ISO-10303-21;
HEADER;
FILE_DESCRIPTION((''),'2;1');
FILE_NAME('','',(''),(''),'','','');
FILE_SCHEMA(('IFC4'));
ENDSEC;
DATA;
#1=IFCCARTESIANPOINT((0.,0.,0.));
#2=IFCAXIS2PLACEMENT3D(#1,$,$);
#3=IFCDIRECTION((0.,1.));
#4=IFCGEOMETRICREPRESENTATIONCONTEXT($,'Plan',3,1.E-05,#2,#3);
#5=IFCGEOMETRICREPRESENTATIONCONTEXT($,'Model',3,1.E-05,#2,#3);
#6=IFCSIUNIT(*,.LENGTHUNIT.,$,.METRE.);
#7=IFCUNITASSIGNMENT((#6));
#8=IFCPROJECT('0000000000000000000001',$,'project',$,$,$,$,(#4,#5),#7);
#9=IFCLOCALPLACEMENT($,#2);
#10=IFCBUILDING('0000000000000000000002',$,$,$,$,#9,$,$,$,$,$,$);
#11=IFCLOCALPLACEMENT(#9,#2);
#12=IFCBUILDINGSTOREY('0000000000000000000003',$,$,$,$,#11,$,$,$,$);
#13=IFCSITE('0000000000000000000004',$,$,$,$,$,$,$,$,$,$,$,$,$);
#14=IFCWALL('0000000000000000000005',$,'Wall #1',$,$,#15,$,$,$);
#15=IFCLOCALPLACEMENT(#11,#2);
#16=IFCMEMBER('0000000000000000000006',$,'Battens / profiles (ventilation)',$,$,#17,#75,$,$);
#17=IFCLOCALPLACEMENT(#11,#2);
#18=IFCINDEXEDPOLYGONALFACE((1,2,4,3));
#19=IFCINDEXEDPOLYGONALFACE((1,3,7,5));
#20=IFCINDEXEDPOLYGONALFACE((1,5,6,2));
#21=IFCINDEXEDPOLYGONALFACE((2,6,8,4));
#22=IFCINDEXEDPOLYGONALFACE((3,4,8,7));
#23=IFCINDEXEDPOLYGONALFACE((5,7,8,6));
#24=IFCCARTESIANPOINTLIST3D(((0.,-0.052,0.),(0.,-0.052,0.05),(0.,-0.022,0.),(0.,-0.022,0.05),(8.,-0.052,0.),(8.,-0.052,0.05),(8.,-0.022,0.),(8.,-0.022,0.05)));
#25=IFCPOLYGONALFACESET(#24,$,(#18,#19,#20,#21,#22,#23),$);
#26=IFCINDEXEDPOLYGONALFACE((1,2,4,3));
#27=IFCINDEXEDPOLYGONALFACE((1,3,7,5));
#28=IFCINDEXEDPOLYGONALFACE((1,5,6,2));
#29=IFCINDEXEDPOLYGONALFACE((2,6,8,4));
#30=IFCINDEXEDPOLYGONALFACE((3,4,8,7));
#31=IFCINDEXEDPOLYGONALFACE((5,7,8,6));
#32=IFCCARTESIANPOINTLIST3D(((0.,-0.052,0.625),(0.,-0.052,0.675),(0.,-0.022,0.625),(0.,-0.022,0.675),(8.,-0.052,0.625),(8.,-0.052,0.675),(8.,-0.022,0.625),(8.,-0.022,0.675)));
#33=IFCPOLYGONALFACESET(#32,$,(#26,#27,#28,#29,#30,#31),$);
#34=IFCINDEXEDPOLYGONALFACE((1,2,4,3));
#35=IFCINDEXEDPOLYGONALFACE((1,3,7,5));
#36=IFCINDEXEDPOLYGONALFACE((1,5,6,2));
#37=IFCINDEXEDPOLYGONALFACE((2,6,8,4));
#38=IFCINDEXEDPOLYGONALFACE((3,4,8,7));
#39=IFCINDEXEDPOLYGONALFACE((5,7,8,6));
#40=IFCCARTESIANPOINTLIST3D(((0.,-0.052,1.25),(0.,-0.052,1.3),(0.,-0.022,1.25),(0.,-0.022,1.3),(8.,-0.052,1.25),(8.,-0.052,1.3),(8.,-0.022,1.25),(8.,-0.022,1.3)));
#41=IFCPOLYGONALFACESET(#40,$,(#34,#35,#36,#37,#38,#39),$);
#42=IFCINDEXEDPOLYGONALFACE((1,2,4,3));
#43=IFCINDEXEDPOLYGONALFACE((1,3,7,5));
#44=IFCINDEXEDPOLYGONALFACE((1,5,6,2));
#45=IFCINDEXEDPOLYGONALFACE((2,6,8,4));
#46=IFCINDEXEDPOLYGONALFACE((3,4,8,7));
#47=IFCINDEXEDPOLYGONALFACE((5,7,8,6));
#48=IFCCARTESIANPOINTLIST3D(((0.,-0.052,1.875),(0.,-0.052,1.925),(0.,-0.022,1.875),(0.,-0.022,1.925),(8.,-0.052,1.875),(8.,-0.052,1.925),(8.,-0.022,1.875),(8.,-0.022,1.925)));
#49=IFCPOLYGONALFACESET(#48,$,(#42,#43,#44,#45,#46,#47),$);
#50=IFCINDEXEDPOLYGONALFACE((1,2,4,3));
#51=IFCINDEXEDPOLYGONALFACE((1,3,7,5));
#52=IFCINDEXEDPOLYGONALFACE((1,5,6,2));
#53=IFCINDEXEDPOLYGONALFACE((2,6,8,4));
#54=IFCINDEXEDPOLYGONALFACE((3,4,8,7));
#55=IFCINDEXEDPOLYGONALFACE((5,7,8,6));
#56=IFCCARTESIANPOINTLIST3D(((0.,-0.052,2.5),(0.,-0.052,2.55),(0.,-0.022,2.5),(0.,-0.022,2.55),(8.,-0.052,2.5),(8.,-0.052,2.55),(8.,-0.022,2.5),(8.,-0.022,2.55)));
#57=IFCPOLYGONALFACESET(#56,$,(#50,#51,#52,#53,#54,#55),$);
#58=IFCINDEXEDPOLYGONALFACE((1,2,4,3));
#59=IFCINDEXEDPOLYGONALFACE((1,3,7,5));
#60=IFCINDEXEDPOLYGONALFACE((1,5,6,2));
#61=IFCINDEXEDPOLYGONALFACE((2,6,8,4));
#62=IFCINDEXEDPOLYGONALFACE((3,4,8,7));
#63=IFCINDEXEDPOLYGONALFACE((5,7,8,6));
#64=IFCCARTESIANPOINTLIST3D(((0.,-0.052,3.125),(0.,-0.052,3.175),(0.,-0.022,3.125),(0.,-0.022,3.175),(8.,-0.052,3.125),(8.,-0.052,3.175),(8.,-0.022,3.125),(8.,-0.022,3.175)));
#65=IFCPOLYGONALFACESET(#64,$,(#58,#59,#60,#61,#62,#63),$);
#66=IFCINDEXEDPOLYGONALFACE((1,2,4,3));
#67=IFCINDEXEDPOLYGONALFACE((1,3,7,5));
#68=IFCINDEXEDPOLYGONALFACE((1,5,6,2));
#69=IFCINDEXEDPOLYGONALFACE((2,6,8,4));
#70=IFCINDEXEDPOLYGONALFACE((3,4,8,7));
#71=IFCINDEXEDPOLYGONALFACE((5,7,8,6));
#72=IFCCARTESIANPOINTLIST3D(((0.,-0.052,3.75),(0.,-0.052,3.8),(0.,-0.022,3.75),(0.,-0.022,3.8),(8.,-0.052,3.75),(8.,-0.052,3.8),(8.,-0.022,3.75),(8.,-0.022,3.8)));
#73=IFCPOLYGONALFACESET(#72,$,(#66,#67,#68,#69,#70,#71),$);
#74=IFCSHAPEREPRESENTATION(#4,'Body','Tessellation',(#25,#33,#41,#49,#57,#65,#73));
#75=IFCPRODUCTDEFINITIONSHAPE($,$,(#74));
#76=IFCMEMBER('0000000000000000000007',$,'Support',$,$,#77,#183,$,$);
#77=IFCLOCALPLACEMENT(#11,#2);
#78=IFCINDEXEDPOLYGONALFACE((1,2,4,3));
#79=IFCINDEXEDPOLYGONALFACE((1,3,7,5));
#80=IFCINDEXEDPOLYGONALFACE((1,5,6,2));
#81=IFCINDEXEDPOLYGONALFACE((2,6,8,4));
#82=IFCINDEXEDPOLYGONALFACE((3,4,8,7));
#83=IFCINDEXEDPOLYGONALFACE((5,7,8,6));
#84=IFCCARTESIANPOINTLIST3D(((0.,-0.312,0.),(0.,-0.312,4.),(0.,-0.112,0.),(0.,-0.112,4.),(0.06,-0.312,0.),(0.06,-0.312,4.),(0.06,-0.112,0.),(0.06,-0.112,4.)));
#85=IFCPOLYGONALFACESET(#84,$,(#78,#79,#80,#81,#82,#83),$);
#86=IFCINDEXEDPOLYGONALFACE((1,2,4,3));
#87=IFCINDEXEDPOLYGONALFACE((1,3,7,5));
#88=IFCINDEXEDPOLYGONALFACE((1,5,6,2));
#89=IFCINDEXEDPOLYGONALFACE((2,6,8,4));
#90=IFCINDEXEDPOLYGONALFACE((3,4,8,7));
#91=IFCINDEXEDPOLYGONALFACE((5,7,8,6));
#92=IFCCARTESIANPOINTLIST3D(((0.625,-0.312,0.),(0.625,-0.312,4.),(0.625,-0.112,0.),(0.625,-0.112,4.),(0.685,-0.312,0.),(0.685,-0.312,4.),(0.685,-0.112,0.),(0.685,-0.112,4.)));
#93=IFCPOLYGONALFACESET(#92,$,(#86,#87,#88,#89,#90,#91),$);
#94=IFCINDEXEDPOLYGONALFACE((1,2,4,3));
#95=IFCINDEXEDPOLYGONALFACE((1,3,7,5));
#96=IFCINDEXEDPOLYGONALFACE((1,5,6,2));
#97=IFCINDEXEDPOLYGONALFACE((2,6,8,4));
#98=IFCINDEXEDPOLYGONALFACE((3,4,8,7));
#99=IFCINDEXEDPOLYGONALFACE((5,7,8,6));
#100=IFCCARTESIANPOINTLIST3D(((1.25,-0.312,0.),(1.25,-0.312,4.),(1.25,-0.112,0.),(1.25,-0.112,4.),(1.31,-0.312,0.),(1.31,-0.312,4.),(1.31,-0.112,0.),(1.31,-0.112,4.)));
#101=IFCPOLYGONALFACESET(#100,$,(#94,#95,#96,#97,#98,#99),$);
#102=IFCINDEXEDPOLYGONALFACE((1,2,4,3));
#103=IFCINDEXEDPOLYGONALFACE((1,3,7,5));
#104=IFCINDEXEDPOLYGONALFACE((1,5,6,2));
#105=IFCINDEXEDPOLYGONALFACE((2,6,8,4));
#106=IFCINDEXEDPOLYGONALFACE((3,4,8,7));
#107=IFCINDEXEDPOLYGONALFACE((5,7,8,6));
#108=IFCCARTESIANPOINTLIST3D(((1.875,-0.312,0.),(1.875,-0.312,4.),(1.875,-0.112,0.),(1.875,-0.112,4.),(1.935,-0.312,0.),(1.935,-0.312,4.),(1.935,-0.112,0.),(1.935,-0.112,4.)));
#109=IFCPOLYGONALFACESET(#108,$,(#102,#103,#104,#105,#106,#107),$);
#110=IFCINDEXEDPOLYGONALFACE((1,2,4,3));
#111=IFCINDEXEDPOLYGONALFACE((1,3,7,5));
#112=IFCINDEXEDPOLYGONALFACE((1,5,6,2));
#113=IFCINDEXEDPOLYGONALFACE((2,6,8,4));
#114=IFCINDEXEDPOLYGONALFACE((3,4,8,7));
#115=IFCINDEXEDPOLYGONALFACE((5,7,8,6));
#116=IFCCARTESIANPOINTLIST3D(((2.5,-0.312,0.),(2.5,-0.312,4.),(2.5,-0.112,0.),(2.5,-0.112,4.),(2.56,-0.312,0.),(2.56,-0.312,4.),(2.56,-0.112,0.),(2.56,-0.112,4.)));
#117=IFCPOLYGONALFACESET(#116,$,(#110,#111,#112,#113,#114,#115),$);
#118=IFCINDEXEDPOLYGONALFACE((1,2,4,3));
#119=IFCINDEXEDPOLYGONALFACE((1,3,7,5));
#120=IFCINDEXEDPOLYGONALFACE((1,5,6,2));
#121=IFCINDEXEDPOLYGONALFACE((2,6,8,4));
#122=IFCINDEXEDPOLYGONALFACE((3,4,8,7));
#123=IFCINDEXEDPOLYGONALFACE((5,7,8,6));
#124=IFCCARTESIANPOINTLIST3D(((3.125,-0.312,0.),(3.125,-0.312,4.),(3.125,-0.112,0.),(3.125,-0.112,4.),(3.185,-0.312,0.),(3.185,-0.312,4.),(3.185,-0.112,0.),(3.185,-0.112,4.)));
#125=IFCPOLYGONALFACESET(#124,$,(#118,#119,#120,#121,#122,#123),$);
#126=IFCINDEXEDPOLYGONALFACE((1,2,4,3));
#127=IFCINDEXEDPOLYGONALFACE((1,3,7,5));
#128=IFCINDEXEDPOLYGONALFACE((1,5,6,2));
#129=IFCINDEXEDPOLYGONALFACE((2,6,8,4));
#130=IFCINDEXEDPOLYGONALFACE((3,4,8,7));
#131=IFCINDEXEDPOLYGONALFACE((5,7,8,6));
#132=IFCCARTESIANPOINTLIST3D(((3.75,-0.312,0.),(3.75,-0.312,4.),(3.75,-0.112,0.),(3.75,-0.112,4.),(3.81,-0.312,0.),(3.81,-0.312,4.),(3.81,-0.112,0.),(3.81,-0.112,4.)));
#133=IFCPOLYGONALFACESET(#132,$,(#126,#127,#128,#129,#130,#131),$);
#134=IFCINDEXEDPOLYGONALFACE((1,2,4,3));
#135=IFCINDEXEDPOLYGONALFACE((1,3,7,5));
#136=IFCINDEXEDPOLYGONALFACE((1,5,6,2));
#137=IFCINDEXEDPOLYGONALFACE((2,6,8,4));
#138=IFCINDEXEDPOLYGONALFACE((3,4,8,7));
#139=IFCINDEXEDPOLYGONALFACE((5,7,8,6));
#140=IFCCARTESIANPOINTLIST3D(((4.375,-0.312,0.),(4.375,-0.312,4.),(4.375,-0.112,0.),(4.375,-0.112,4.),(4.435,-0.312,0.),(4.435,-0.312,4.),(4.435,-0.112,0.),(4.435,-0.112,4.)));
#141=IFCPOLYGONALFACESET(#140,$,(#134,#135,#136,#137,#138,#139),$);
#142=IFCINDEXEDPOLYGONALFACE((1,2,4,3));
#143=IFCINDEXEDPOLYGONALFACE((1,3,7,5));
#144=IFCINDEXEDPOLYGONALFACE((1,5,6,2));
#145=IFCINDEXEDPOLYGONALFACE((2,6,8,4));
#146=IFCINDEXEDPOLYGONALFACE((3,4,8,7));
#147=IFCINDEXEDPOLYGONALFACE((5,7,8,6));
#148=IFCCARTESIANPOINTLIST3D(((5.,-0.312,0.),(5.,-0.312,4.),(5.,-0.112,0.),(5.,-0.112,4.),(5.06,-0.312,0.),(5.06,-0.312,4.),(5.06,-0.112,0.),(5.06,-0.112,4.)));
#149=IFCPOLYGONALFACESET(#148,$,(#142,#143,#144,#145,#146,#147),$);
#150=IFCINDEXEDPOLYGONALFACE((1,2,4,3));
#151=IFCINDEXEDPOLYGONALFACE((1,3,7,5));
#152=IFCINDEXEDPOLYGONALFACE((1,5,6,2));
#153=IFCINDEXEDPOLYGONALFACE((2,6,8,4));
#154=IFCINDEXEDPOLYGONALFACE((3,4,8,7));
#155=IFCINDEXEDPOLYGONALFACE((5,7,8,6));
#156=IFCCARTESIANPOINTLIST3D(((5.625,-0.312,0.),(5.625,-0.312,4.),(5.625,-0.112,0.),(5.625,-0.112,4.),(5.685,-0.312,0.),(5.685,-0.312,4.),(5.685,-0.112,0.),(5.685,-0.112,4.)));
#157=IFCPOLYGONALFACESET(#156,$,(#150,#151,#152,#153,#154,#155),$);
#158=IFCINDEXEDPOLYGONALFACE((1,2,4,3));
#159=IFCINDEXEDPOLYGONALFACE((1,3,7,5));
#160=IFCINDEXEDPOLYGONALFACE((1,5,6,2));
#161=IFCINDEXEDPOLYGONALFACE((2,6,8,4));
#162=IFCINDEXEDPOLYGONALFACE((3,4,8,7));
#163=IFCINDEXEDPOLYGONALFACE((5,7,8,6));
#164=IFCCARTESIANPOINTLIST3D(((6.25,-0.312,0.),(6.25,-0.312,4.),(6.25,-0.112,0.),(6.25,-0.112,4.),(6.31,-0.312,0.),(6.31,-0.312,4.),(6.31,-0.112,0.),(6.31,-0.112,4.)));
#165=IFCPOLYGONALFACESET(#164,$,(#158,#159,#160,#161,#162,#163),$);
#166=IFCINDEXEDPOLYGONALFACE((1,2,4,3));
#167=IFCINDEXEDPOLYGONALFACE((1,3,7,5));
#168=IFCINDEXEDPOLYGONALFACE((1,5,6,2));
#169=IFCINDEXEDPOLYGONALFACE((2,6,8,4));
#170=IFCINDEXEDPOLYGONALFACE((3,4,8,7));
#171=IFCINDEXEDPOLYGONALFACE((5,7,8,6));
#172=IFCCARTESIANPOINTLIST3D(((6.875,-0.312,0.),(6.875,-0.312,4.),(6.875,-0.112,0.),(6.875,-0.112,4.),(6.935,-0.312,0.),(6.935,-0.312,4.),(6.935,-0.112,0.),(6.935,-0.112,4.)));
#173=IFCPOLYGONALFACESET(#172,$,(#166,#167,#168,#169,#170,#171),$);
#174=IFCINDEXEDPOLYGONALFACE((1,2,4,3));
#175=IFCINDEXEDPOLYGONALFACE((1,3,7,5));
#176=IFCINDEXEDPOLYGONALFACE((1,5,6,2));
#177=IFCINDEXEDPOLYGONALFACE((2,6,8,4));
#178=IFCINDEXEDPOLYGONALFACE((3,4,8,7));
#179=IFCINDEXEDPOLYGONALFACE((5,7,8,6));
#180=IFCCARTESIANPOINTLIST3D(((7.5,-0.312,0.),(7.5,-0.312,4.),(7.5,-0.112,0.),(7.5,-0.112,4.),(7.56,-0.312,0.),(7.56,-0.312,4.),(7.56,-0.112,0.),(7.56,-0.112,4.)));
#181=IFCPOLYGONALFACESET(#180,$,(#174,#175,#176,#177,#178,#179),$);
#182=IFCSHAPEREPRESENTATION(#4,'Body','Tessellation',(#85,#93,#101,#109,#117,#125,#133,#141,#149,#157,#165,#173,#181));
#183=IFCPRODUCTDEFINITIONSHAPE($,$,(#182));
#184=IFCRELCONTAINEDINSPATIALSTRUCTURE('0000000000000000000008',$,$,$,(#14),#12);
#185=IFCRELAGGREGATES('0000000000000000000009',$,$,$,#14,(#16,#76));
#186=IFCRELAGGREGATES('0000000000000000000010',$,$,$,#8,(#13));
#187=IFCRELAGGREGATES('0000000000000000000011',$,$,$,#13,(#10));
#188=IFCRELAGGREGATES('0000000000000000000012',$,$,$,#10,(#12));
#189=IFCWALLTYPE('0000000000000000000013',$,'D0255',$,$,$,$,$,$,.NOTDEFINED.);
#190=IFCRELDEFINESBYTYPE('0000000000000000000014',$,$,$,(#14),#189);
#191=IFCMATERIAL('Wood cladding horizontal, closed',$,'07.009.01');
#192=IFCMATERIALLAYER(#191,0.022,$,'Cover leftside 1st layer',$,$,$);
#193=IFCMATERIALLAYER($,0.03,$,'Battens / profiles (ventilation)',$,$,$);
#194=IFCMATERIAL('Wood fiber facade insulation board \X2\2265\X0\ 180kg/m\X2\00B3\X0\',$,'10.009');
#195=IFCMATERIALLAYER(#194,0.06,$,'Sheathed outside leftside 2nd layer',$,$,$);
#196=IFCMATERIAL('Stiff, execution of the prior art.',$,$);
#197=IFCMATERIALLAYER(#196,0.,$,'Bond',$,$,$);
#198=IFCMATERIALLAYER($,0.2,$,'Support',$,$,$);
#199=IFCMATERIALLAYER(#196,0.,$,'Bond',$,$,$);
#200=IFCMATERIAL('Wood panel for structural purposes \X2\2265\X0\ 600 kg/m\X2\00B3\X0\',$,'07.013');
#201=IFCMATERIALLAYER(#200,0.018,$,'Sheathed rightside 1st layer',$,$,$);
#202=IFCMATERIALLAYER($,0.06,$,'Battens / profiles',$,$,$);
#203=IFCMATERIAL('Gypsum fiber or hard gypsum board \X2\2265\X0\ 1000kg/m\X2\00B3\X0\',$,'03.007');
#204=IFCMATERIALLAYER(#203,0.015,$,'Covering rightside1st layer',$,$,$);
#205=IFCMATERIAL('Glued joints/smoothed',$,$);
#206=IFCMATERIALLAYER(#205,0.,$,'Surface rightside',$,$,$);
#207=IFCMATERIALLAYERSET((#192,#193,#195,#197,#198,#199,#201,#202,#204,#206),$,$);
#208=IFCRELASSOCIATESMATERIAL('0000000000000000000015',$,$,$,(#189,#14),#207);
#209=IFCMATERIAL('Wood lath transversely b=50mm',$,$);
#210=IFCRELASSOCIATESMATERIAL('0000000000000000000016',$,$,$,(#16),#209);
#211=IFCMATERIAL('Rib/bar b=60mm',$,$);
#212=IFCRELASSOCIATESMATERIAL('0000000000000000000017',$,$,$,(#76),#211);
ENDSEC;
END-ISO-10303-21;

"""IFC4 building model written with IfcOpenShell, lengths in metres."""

from ifc_helpers import new_model, si_unit, direction, frame, frame_2d, origin, place, context, project, spatial, rectangle, extrude, material, layer, layer_set, type_object, element, aggregate, save


model = new_model("IFC4")

# Units and contexts
plan_context = context("Plan", 3, precision=1e-05, world=origin(), true_north=direction((0.0, 1.0)))
model_context = context("Model", 3, precision=1e-05, world=origin(), true_north=direction((0.0, 1.0)))
ifc_project = project(units=[si_unit("LENGTHUNIT", "METRE")], contexts=[plan_context, model_context])

# Site, building, storey
site = spatial("IfcSite", under=ifc_project)
building_placement = place(None, origin())
building = spatial("IfcBuilding", under=site, at=building_placement)
storey_placement = place(building_placement, origin())
storey = spatial("IfcBuildingStorey", under=building, at=storey_placement)

# Wall, members
ifc_material_1 = material(Name="Wood cladding horizontal, closed", Category="07.009.01")
ifc_layer_1 = layer(ifc_material_1, 0.022, Name="Cover leftside 1st layer")
ifc_layer_2 = layer(None, 0.03, Name="Battens / profiles (ventilation)")
ifc_material_2 = material(Name="Wood fiber facade insulation board ≥ 180kg/m³", Category="10.009")
ifc_layer_3 = layer(ifc_material_2, 0.06, Name="Sheathed outside leftside 2nd layer")
ifc_material_3 = material(Name="Stiff, execution of the prior art.")
ifc_layer_4 = layer(ifc_material_3, 0.0, Name="Bond")
ifc_layer_5 = layer(None, 0.2, Name="Support")
ifc_layer_6 = layer(ifc_material_3, 0.0, Name="Bond")
ifc_material_4 = material(Name="Wood panel for structural purposes ≥ 600 kg/m³", Category="07.013")
ifc_layer_7 = layer(ifc_material_4, 0.018, Name="Sheathed rightside 1st layer")
ifc_layer_8 = layer(None, 0.06, Name="Battens / profiles")
ifc_material_5 = material(Name="Gypsum fiber or hard gypsum board ≥ 1000kg/m³", Category="03.007")
ifc_layer_9 = layer(ifc_material_5, 0.015, Name="Covering rightside1st layer")
ifc_material_6 = material(Name="Glued joints/smoothed")
ifc_layer_10 = layer(ifc_material_6, 0.0, Name="Surface rightside")
ifc_layer_set = layer_set([ifc_layer_1, ifc_layer_2, ifc_layer_3, ifc_layer_4, ifc_layer_5, ifc_layer_6, ifc_layer_7, ifc_layer_8, ifc_layer_9, ifc_layer_10])
wall_type = type_object("IfcWallType", Name="D0255", PredefinedType="NOTDEFINED", material=ifc_layer_set)
wall_placement = place(None, frame((0.0, 0.0, 0.0), z_axis=(0.0, -1.0, 0.0), x_axis=(1.0, 0.0, 0.0)))
wall = element("IfcWall", 1, at=wall_placement, inside=storey, type_object=wall_type, material=ifc_layer_set, Name="Wall #1")
ifc_material_7 = material(Name="Wood lath transversely b=50mm")
member_1_placement = place(wall_placement, origin())
member_1 = element("IfcMember", 2, at=member_1_placement, material=ifc_material_7, Name="Battens / profiles (ventilation)", context=plan_context, shape_type="SweptSolid", body=[
    extrude(rectangle(XDim=0.05, YDim=0.03, at=frame_2d((0.025, 0.015), x_axis=(1.0, 0.0))), frame((0.0, 0.0, 0.022), z_axis=(1.0, 0.0, 0.0), x_axis=(0.0, 1.0, 0.0)), (0.0, 0.0, 1.0), 8.0),
    extrude(rectangle(XDim=0.05, YDim=0.03, at=frame_2d((0.025, 0.015), x_axis=(1.0, 0.0))), frame((0.0, 0.625, 0.022), z_axis=(1.0, 0.0, 0.0), x_axis=(0.0, 1.0, 0.0)), (0.0, 0.0, 1.0), 8.0),
    extrude(rectangle(XDim=0.05, YDim=0.03, at=frame_2d((0.025, 0.015), x_axis=(1.0, 0.0))), frame((0.0, 1.25, 0.022), z_axis=(1.0, 0.0, 0.0), x_axis=(0.0, 1.0, 0.0)), (0.0, 0.0, 1.0), 8.0),
    extrude(rectangle(XDim=0.05, YDim=0.03, at=frame_2d((0.025, 0.015), x_axis=(1.0, 0.0))), frame((0.0, 1.875, 0.022), z_axis=(1.0, 0.0, 0.0), x_axis=(0.0, 1.0, 0.0)), (0.0, 0.0, 1.0), 8.0),
    extrude(rectangle(XDim=0.05, YDim=0.03, at=frame_2d((0.025, 0.015), x_axis=(1.0, 0.0))), frame((0.0, 2.5, 0.022), z_axis=(1.0, 0.0, 0.0), x_axis=(0.0, 1.0, 0.0)), (0.0, 0.0, 1.0), 8.0),
    extrude(rectangle(XDim=0.05, YDim=0.03, at=frame_2d((0.025, 0.015), x_axis=(1.0, 0.0))), frame((0.0, 3.125, 0.022), z_axis=(1.0, 0.0, 0.0), x_axis=(0.0, 1.0, 0.0)), (0.0, 0.0, 1.0), 8.0),
    extrude(rectangle(XDim=0.05, YDim=0.03, at=frame_2d((0.025, 0.015), x_axis=(1.0, 0.0))), frame((0.0, 3.75, 0.022), z_axis=(1.0, 0.0, 0.0), x_axis=(0.0, 1.0, 0.0)), (0.0, 0.0, 1.0), 8.0),
])
ifc_material_8 = material(Name="Rib/bar b=60mm")
member_2_placement = place(wall_placement, origin())
member_2 = element("IfcMember", 3, at=member_2_placement, material=ifc_material_8, Name="Support", context=plan_context, shape_type="SweptSolid", body=[
    extrude(rectangle(XDim=0.06, YDim=0.2, at=frame_2d((0.03, 0.1), x_axis=(1.0, 0.0))), frame((0.0, 4.0, 0.112), z_axis=(0.0, -1.0, 0.0), x_axis=(1.0, 0.0, 0.0)), (0.0, 0.0, 1.0), 4.0),
    extrude(rectangle(XDim=0.06, YDim=0.2, at=frame_2d((0.03, 0.1), x_axis=(1.0, 0.0))), frame((0.625, 4.0, 0.112), z_axis=(0.0, -1.0, 0.0), x_axis=(1.0, 0.0, 0.0)), (0.0, 0.0, 1.0), 4.0),
    extrude(rectangle(XDim=0.06, YDim=0.2, at=frame_2d((0.03, 0.1), x_axis=(1.0, 0.0))), frame((1.25, 4.0, 0.112), z_axis=(0.0, -1.0, 0.0), x_axis=(1.0, 0.0, 0.0)), (0.0, 0.0, 1.0), 4.0),
    extrude(rectangle(XDim=0.06, YDim=0.2, at=frame_2d((0.03, 0.1), x_axis=(1.0, 0.0))), frame((1.875, 4.0, 0.112), z_axis=(0.0, -1.0, 0.0), x_axis=(1.0, 0.0, 0.0)), (0.0, 0.0, 1.0), 4.0),
    extrude(rectangle(XDim=0.06, YDim=0.2, at=frame_2d((0.03, 0.1), x_axis=(1.0, 0.0))), frame((2.5, 4.0, 0.112), z_axis=(0.0, -1.0, 0.0), x_axis=(1.0, 0.0, 0.0)), (0.0, 0.0, 1.0), 4.0),
    extrude(rectangle(XDim=0.06, YDim=0.2, at=frame_2d((0.03, 0.1), x_axis=(1.0, 0.0))), frame((3.125, 4.0, 0.112), z_axis=(0.0, -1.0, 0.0), x_axis=(1.0, 0.0, 0.0)), (0.0, 0.0, 1.0), 4.0),
    extrude(rectangle(XDim=0.06, YDim=0.2, at=frame_2d((0.03, 0.1), x_axis=(1.0, 0.0))), frame((3.75, 4.0, 0.112), z_axis=(0.0, -1.0, 0.0), x_axis=(1.0, 0.0, 0.0)), (0.0, 0.0, 1.0), 4.0),
    extrude(rectangle(XDim=0.06, YDim=0.2, at=frame_2d((0.03, 0.1), x_axis=(1.0, 0.0))), frame((4.375, 4.0, 0.112), z_axis=(0.0, -1.0, 0.0), x_axis=(1.0, 0.0, 0.0)), (0.0, 0.0, 1.0), 4.0),
    extrude(rectangle(XDim=0.06, YDim=0.2, at=frame_2d((0.03, 0.1), x_axis=(1.0, 0.0))), frame((5.0, 4.0, 0.112), z_axis=(0.0, -1.0, 0.0), x_axis=(1.0, 0.0, 0.0)), (0.0, 0.0, 1.0), 4.0),
    extrude(rectangle(XDim=0.06, YDim=0.2, at=frame_2d((0.03, 0.1), x_axis=(1.0, 0.0))), frame((5.625, 4.0, 0.112), z_axis=(0.0, -1.0, 0.0), x_axis=(1.0, 0.0, 0.0)), (0.0, 0.0, 1.0), 4.0),
    extrude(rectangle(XDim=0.06, YDim=0.2, at=frame_2d((0.03, 0.1), x_axis=(1.0, 0.0))), frame((6.25, 4.0, 0.112), z_axis=(0.0, -1.0, 0.0), x_axis=(1.0, 0.0, 0.0)), (0.0, 0.0, 1.0), 4.0),
    extrude(rectangle(XDim=0.06, YDim=0.2, at=frame_2d((0.03, 0.1), x_axis=(1.0, 0.0))), frame((6.875, 4.0, 0.112), z_axis=(0.0, -1.0, 0.0), x_axis=(1.0, 0.0, 0.0)), (0.0, 0.0, 1.0), 4.0),
    extrude(rectangle(XDim=0.06, YDim=0.2, at=frame_2d((0.03, 0.1), x_axis=(1.0, 0.0))), frame((7.5, 4.0, 0.112), z_axis=(0.0, -1.0, 0.0), x_axis=(1.0, 0.0, 0.0)), (0.0, 0.0, 1.0), 4.0),
])
aggregate(wall, [member_1, member_2])

save(model, "model.ifc")
